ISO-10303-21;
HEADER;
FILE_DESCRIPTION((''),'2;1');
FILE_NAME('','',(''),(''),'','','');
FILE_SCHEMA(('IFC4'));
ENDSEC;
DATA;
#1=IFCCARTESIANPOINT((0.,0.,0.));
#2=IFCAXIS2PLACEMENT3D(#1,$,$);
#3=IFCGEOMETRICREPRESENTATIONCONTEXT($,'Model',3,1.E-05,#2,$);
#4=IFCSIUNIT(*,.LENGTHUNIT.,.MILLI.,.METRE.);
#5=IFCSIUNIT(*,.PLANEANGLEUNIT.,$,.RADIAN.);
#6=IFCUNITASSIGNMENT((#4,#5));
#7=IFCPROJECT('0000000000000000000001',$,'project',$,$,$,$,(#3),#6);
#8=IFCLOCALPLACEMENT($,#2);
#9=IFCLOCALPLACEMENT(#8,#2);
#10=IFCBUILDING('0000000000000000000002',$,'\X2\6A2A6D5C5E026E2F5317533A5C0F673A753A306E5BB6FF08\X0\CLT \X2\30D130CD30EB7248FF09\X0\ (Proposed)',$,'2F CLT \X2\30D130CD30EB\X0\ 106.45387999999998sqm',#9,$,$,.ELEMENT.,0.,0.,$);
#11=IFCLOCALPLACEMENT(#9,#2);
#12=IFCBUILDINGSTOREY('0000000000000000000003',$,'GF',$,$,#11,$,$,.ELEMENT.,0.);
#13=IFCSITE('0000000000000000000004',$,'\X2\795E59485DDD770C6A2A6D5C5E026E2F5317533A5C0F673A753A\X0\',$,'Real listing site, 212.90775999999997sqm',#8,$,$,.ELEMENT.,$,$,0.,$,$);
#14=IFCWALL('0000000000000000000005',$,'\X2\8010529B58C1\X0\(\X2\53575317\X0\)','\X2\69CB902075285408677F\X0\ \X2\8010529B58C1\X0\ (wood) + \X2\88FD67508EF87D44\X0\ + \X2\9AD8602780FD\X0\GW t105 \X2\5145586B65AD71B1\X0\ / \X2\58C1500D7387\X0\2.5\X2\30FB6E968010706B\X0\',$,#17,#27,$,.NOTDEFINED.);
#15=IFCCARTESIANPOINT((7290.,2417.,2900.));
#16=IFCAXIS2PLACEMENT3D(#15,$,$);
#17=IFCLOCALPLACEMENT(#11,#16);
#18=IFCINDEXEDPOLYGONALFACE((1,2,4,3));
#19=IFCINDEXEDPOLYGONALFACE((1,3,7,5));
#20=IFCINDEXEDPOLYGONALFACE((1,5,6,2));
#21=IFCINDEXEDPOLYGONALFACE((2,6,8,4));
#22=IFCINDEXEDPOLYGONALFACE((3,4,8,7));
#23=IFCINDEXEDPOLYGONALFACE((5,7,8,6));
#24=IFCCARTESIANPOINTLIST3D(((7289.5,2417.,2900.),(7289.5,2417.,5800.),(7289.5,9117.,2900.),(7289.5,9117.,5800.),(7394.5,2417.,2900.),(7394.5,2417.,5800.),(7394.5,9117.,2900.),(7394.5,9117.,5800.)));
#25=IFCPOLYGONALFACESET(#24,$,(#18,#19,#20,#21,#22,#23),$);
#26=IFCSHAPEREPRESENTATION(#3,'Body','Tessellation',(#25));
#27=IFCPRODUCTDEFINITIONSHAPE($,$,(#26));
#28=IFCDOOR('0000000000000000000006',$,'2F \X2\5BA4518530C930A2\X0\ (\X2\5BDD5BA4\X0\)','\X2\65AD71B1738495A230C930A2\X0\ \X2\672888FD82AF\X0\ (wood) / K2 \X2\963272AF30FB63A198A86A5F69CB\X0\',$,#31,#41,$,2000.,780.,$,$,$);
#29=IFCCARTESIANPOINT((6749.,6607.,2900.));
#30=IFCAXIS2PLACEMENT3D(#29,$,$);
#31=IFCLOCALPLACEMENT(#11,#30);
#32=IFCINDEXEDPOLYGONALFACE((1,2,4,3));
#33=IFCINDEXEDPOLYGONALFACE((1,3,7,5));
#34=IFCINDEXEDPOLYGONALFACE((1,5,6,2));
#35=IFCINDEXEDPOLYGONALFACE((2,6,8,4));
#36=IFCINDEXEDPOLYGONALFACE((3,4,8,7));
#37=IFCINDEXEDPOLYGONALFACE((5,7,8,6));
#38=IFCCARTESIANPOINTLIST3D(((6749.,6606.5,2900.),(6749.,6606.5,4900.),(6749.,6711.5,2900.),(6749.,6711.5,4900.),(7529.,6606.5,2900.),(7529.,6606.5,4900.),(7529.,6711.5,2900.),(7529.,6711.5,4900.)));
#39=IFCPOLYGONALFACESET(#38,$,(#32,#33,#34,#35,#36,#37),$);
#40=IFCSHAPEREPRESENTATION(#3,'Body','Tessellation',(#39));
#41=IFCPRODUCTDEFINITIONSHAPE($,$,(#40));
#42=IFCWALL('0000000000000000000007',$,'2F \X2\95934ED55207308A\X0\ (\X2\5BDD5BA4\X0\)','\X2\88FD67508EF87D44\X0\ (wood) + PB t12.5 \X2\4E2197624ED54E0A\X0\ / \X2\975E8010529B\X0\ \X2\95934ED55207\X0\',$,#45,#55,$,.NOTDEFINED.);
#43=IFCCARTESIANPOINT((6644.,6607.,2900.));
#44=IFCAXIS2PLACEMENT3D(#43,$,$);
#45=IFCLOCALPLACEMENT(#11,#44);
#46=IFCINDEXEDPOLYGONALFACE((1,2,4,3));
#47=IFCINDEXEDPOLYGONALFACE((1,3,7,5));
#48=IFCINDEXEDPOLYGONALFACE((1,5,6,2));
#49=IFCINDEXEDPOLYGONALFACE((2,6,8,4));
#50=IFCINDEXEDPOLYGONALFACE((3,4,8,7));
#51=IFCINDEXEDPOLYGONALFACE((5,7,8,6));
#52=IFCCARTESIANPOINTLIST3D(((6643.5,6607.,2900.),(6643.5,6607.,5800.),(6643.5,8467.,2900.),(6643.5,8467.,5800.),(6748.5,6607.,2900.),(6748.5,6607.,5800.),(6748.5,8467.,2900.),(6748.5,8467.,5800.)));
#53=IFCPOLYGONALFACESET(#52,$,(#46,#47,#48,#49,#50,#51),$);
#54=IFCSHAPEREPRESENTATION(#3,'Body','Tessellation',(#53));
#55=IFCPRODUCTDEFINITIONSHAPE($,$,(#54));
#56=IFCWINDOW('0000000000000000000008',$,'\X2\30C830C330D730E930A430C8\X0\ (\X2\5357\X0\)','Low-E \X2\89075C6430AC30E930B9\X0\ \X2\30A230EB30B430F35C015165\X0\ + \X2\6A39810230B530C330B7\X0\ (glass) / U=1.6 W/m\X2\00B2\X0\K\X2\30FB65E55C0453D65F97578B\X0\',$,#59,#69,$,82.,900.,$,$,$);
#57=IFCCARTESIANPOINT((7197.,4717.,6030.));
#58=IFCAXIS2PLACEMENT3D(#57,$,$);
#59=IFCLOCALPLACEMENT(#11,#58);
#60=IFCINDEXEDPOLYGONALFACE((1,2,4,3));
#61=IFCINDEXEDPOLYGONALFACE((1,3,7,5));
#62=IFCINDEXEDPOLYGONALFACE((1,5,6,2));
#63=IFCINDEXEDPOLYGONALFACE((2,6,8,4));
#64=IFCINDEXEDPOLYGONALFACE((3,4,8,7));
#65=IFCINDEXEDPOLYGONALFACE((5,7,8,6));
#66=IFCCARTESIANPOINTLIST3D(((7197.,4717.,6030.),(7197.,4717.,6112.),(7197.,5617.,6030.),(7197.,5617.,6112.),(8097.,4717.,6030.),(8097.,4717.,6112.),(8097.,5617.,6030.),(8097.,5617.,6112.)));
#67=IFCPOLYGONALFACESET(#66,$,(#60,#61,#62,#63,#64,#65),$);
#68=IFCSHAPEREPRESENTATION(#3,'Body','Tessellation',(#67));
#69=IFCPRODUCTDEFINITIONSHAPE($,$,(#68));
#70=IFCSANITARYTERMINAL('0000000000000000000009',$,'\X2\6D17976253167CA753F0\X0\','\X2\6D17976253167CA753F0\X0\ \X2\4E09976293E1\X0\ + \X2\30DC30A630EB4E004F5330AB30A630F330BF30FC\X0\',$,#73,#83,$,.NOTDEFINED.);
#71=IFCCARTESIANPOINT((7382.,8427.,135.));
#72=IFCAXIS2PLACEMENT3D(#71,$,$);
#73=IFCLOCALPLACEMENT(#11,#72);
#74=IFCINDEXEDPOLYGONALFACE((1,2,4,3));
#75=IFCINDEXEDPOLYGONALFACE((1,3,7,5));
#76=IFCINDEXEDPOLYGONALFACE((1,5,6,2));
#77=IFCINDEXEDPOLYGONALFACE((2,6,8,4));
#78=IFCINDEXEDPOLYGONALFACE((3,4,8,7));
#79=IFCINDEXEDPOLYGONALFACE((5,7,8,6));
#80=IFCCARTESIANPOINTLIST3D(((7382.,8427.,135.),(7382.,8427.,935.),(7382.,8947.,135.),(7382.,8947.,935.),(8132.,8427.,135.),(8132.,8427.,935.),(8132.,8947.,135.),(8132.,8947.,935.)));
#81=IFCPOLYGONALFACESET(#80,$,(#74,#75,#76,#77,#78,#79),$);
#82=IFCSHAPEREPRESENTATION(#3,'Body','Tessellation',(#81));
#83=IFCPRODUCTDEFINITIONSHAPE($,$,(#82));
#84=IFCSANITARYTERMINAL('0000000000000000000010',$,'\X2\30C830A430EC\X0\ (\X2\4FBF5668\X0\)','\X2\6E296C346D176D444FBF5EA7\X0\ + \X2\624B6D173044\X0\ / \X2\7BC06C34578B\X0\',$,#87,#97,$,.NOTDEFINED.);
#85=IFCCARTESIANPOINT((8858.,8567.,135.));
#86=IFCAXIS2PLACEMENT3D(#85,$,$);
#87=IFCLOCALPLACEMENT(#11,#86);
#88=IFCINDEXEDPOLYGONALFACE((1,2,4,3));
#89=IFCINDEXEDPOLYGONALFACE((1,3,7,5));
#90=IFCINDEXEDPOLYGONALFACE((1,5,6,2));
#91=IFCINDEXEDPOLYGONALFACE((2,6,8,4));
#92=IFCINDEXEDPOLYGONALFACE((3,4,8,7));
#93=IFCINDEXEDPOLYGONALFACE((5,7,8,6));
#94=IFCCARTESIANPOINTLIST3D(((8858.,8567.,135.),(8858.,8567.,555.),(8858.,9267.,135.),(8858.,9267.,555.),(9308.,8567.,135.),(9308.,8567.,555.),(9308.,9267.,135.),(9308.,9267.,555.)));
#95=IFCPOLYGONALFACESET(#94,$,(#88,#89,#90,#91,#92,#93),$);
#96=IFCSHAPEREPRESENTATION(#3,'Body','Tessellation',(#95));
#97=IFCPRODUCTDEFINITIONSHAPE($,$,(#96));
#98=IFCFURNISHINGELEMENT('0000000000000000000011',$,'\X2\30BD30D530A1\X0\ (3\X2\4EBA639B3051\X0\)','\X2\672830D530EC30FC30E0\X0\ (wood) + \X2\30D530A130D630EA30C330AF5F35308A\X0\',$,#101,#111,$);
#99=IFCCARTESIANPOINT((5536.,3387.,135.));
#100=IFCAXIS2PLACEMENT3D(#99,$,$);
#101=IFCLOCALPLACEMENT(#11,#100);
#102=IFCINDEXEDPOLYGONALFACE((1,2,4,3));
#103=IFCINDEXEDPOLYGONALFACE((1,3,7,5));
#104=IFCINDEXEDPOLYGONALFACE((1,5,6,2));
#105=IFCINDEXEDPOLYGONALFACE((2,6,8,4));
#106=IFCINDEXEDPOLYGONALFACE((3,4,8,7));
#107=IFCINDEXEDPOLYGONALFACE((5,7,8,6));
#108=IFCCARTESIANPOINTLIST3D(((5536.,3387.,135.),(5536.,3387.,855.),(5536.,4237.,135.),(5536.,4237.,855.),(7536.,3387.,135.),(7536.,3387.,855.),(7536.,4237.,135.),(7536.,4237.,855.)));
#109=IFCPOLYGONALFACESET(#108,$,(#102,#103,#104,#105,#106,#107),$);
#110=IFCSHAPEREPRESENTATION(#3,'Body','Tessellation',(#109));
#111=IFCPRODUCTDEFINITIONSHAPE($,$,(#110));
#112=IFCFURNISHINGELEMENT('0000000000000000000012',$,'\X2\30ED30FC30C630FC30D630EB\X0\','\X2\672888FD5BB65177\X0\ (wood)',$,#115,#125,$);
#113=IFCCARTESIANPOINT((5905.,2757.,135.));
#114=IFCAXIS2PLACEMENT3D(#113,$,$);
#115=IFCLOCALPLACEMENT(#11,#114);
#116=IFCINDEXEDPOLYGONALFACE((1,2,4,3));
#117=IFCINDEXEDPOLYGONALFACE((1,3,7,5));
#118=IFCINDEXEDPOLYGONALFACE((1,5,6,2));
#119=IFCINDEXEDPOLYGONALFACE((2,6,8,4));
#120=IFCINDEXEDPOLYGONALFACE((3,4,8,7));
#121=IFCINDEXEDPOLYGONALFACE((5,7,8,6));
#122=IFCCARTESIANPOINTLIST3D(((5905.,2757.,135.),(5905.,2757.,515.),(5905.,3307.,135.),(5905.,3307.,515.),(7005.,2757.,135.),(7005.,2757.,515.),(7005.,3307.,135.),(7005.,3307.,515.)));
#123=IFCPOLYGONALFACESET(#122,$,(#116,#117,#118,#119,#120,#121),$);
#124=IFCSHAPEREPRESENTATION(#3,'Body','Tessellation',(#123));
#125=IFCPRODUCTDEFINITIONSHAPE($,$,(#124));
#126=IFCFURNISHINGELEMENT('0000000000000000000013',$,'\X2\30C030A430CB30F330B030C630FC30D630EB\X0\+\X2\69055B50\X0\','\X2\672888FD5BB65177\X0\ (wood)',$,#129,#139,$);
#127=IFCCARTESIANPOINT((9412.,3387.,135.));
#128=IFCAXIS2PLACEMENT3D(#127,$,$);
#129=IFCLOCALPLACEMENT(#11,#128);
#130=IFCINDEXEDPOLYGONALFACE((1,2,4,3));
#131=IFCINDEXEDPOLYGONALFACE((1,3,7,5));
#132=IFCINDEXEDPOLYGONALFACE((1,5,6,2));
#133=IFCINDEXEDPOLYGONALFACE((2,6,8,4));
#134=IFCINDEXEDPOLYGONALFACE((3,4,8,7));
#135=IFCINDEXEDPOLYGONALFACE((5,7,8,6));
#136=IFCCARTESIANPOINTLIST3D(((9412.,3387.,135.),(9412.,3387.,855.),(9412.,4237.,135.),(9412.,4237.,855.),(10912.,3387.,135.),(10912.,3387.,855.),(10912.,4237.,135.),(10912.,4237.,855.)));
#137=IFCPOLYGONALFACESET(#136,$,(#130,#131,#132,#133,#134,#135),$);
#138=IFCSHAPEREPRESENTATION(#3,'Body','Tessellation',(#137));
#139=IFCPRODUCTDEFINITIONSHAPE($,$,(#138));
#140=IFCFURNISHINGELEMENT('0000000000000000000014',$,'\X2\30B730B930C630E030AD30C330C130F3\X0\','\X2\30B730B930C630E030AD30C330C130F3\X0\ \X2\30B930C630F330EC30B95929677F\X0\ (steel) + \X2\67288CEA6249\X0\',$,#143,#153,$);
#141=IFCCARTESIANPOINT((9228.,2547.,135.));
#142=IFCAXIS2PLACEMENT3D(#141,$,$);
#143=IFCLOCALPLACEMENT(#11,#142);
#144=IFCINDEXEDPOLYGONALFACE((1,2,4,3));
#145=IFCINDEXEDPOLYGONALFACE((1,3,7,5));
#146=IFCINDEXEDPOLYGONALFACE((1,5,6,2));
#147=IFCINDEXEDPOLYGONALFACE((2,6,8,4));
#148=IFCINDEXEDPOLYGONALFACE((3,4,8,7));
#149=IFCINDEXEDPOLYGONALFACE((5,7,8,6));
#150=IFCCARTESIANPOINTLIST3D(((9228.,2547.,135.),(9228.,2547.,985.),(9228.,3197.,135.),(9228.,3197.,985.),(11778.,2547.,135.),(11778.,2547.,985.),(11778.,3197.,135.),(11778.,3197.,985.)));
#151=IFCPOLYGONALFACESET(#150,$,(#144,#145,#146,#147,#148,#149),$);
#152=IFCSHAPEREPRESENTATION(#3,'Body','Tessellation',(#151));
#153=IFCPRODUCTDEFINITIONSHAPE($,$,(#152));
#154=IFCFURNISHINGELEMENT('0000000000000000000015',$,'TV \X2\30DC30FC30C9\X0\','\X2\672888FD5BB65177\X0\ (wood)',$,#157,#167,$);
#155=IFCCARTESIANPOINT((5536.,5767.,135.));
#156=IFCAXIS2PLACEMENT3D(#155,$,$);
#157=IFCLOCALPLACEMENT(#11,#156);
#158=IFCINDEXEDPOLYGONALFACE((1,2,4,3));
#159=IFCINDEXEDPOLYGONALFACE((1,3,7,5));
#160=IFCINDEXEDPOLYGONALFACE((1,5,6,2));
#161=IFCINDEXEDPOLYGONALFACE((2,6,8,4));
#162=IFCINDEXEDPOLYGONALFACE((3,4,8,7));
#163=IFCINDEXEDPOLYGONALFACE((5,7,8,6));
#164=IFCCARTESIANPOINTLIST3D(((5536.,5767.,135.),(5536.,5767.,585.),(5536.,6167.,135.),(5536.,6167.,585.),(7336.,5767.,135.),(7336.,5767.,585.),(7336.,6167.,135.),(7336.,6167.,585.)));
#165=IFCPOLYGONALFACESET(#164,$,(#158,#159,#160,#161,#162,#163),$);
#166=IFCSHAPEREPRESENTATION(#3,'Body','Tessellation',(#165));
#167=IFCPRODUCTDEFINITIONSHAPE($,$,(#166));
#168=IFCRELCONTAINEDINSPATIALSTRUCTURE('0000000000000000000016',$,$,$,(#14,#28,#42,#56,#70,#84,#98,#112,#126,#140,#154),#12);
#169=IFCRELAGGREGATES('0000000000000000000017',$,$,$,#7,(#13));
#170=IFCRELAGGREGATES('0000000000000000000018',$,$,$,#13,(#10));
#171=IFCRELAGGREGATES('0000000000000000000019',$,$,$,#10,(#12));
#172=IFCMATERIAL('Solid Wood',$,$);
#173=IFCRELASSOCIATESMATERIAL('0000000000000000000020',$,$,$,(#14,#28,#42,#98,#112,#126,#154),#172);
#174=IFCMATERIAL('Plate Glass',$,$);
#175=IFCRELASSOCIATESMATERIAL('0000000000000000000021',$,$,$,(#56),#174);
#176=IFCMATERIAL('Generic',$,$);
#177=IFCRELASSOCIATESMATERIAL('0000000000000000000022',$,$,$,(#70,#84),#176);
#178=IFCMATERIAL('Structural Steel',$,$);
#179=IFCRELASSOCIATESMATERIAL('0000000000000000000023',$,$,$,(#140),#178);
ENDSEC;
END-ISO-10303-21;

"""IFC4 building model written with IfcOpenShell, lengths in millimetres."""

from ifc_helpers import new_model, si_unit, frame, frame_2d, origin, place, context, project, spatial, rectangle, extrude, material, element, fill, save


model = new_model("IFC4")

# Units and contexts
model_context = context("Model", 3, precision=1e-05, world=origin())
ifc_project = project(units=[si_unit("LENGTHUNIT", "METRE", prefix="MILLI"), si_unit("PLANEANGLEUNIT", "RADIAN")], contexts=[model_context])

# Site, building, storey
site_placement = place(None, origin())
site = spatial("IfcSite", under=ifc_project, at=site_placement, Name="神奈川県横浜市港北区小机町", ObjectType="Real listing site, 212.90775999999997sqm", CompositionType="ELEMENT", RefElevation=0.0)
building_placement = place(site_placement, origin())
building = spatial("IfcBuilding", under=site, at=building_placement, Name="横浜市港北区小机町の家（CLT パネル版） (Proposed)", ObjectType="2F CLT パネル 106.45387999999998sqm", CompositionType="ELEMENT", ElevationOfRefHeight=0.0, ElevationOfTerrain=0.0)
storey_placement = place(building_placement, origin())
storey = spatial("IfcBuildingStorey", under=building, at=storey_placement, Name="GF", CompositionType="ELEMENT", Elevation=0.0)

# Shared definitions
ifc_material_1 = material(Name="Solid Wood")

# Wall, opening, door
wall_1_placement = place(storey_placement, frame((7290.0, 2417.0, 2900.0)))
wall_1 = element("IfcWall", 1, at=wall_1_placement, inside=storey, material=ifc_material_1, Name="耐力壁(南北)", Description="構造用合板 耐力壁 (wood) + 製材軸組 + 高性能GW t105 充填断熱 / 壁倍率2.5・準耐火", PredefinedType="NOTDEFINED", context=model_context, shape_type="SweptSolid", body=[
    extrude(rectangle(XDim=105.0, YDim=6700.0, at=frame_2d((52.0, 3350.0))), frame((7290.0, 2417.0, 2900.0)), (0.0, 0.0, 1.0), 2900.0),
])
opening_1_placement = place(storey_placement, frame((6749.0, 6607.0, 2900.0)))
opening_1 = element("IfcOpeningElement", 2, at=opening_1_placement, cuts=wall_1, PredefinedType="NOTDEFINED", context=model_context, shape_type="SweptSolid", body=[
    extrude(rectangle(XDim=780.0, YDim=105.0, at=frame_2d((390.0, 52.0))), frame((6749.0, 6607.0, 2900.0)), (0.0, 0.0, 1.0), 2000.0),
])
door_1_placement = place(storey_placement, frame((6749.0, 6607.0, 2900.0)))
door_1 = element("IfcDoor", 3, at=door_1_placement, inside=storey, material=ifc_material_1, Name="2F 室内ドア (寝室)", Description="断熱玄関ドア 木製芯 (wood) / K2 防犯・採風機構", OverallHeight=2000.0, OverallWidth=780.0, context=model_context, shape_type="SweptSolid", body=[
    extrude(rectangle(XDim=780.0, YDim=105.0, at=frame_2d((390.0, 52.0))), frame((6749.0, 6607.0, 2900.0)), (0.0, 0.0, 1.0), 2000.0),
])
fill(opening_1, door_1)

# Wall
wall_2_placement = place(storey_placement, frame((6644.0, 6607.0, 2900.0)))
element("IfcWall", 4, at=wall_2_placement, inside=storey, material=ifc_material_1, Name="2F 間仕切り (寝室)", Description="製材軸組 (wood) + PB t12.5 両面仕上 / 非耐力 間仕切", PredefinedType="NOTDEFINED", context=model_context, shape_type="SweptSolid", body=[
    extrude(rectangle(XDim=105.0, YDim=1860.0, at=frame_2d((52.0, 930.0))), frame((6644.0, 6607.0, 2900.0)), (0.0, 0.0, 1.0), 2900.0),
])

# Window
ifc_material_2 = material(Name="Plate Glass")
window_placement = place(storey_placement, frame((7197.0, 4717.0, 6030.0)))
element("IfcWindow", 5, at=window_placement, inside=storey, material=ifc_material_2, Name="トップライト (南)", Description="Low-E 複層ガラス アルゴン封入 + 樹脂サッシ (glass) / U=1.6 W/m²K・日射取得型", OverallHeight=82.0, OverallWidth=900.0, context=model_context, shape_type="SweptSolid", body=[
    extrude(rectangle(XDim=900.0, YDim=900.0, at=frame_2d((450.0, 450.0))), frame((7197.0, 4717.0, 6030.0)), (0.0, 0.0, 1.0), 82.0),
])

# Sanitary terminals
ifc_material_3 = material(Name="Generic")
sanitary_terminal_1_placement = place(storey_placement, frame((7382.0, 8427.0, 135.0)))
element("IfcSanitaryTerminal", 6, at=sanitary_terminal_1_placement, inside=storey, material=ifc_material_3, Name="洗面化粧台", Description="洗面化粧台 三面鏡 + ボウル一体カウンター", PredefinedType="NOTDEFINED", context=model_context, shape_type="SweptSolid", body=[
    extrude(rectangle(XDim=750.0, YDim=520.0, at=frame_2d((375.0, 260.0))), frame((7382.0, 8427.0, 135.0)), (0.0, 0.0, 1.0), 800.0),
])
sanitary_terminal_2_placement = place(storey_placement, frame((8858.0, 8567.0, 135.0)))
element("IfcSanitaryTerminal", 7, at=sanitary_terminal_2_placement, inside=storey, material=ifc_material_3, Name="トイレ (便器)", Description="温水洗浄便座 + 手洗い / 節水型", PredefinedType="NOTDEFINED", context=model_context, shape_type="SweptSolid", body=[
    extrude(rectangle(XDim=450.0, YDim=700.0, at=frame_2d((225.0, 350.0))), frame((8858.0, 8567.0, 135.0)), (0.0, 0.0, 1.0), 420.0),
])

# Furnishing elements
furnishing_1_placement = place(storey_placement, frame((5536.0, 3387.0, 135.0)))
element("IfcFurnishingElement", 8, at=furnishing_1_placement, inside=storey, material=ifc_material_1, Name="ソファ (3人掛け)", Description="木フレーム (wood) + ファブリック張り", context=model_context, shape_type="SweptSolid", body=[
    extrude(rectangle(XDim=2000.0, YDim=850.0, at=frame_2d((1000.0, 425.0))), frame((5536.0, 3387.0, 135.0)), (0.0, 0.0, 1.0), 720.0),
])
furnishing_2_placement = place(storey_placement, frame((5905.0, 2757.0, 135.0)))
element("IfcFurnishingElement", 9, at=furnishing_2_placement, inside=storey, material=ifc_material_1, Name="ローテーブル", Description="木製家具 (wood)", context=model_context, shape_type="SweptSolid", body=[
    extrude(rectangle(XDim=1100.0, YDim=550.0, at=frame_2d((550.0, 275.0))), frame((5905.0, 2757.0, 135.0)), (0.0, 0.0, 1.0), 380.0),
])
furnishing_3_placement = place(storey_placement, frame((9412.0, 3387.0, 135.0)))
element("IfcFurnishingElement", 10, at=furnishing_3_placement, inside=storey, material=ifc_material_1, Name="ダイニングテーブル+椅子", Description="木製家具 (wood)", context=model_context, shape_type="SweptSolid", body=[
    extrude(rectangle(XDim=1500.0, YDim=850.0, at=frame_2d((750.0, 425.0))), frame((9412.0, 3387.0, 135.0)), (0.0, 0.0, 1.0), 720.0),
])
ifc_material_4 = material(Name="Structural Steel")
furnishing_4_placement = place(storey_placement, frame((9228.0, 2547.0, 135.0)))
element("IfcFurnishingElement", 11, at=furnishing_4_placement, inside=storey, material=ifc_material_4, Name="システムキッチン", Description="システムキッチン ステンレス天板 (steel) + 木質扉", context=model_context, shape_type="SweptSolid", body=[
    extrude(rectangle(XDim=2550.0, YDim=650.0, at=frame_2d((1275.0, 325.0))), frame((9228.0, 2547.0, 135.0)), (0.0, 0.0, 1.0), 850.0),
])
furnishing_5_placement = place(storey_placement, frame((5536.0, 5767.0, 135.0)))
element("IfcFurnishingElement", 12, at=furnishing_5_placement, inside=storey, material=ifc_material_1, Name="TV ボード", Description="木製家具 (wood)", context=model_context, shape_type="SweptSolid", body=[
    extrude(rectangle(XDim=1800.0, YDim=400.0, at=frame_2d((900.0, 200.0))), frame((5536.0, 5767.0, 135.0)), (0.0, 0.0, 1.0), 450.0),
])

save(model, "model.ifc")
